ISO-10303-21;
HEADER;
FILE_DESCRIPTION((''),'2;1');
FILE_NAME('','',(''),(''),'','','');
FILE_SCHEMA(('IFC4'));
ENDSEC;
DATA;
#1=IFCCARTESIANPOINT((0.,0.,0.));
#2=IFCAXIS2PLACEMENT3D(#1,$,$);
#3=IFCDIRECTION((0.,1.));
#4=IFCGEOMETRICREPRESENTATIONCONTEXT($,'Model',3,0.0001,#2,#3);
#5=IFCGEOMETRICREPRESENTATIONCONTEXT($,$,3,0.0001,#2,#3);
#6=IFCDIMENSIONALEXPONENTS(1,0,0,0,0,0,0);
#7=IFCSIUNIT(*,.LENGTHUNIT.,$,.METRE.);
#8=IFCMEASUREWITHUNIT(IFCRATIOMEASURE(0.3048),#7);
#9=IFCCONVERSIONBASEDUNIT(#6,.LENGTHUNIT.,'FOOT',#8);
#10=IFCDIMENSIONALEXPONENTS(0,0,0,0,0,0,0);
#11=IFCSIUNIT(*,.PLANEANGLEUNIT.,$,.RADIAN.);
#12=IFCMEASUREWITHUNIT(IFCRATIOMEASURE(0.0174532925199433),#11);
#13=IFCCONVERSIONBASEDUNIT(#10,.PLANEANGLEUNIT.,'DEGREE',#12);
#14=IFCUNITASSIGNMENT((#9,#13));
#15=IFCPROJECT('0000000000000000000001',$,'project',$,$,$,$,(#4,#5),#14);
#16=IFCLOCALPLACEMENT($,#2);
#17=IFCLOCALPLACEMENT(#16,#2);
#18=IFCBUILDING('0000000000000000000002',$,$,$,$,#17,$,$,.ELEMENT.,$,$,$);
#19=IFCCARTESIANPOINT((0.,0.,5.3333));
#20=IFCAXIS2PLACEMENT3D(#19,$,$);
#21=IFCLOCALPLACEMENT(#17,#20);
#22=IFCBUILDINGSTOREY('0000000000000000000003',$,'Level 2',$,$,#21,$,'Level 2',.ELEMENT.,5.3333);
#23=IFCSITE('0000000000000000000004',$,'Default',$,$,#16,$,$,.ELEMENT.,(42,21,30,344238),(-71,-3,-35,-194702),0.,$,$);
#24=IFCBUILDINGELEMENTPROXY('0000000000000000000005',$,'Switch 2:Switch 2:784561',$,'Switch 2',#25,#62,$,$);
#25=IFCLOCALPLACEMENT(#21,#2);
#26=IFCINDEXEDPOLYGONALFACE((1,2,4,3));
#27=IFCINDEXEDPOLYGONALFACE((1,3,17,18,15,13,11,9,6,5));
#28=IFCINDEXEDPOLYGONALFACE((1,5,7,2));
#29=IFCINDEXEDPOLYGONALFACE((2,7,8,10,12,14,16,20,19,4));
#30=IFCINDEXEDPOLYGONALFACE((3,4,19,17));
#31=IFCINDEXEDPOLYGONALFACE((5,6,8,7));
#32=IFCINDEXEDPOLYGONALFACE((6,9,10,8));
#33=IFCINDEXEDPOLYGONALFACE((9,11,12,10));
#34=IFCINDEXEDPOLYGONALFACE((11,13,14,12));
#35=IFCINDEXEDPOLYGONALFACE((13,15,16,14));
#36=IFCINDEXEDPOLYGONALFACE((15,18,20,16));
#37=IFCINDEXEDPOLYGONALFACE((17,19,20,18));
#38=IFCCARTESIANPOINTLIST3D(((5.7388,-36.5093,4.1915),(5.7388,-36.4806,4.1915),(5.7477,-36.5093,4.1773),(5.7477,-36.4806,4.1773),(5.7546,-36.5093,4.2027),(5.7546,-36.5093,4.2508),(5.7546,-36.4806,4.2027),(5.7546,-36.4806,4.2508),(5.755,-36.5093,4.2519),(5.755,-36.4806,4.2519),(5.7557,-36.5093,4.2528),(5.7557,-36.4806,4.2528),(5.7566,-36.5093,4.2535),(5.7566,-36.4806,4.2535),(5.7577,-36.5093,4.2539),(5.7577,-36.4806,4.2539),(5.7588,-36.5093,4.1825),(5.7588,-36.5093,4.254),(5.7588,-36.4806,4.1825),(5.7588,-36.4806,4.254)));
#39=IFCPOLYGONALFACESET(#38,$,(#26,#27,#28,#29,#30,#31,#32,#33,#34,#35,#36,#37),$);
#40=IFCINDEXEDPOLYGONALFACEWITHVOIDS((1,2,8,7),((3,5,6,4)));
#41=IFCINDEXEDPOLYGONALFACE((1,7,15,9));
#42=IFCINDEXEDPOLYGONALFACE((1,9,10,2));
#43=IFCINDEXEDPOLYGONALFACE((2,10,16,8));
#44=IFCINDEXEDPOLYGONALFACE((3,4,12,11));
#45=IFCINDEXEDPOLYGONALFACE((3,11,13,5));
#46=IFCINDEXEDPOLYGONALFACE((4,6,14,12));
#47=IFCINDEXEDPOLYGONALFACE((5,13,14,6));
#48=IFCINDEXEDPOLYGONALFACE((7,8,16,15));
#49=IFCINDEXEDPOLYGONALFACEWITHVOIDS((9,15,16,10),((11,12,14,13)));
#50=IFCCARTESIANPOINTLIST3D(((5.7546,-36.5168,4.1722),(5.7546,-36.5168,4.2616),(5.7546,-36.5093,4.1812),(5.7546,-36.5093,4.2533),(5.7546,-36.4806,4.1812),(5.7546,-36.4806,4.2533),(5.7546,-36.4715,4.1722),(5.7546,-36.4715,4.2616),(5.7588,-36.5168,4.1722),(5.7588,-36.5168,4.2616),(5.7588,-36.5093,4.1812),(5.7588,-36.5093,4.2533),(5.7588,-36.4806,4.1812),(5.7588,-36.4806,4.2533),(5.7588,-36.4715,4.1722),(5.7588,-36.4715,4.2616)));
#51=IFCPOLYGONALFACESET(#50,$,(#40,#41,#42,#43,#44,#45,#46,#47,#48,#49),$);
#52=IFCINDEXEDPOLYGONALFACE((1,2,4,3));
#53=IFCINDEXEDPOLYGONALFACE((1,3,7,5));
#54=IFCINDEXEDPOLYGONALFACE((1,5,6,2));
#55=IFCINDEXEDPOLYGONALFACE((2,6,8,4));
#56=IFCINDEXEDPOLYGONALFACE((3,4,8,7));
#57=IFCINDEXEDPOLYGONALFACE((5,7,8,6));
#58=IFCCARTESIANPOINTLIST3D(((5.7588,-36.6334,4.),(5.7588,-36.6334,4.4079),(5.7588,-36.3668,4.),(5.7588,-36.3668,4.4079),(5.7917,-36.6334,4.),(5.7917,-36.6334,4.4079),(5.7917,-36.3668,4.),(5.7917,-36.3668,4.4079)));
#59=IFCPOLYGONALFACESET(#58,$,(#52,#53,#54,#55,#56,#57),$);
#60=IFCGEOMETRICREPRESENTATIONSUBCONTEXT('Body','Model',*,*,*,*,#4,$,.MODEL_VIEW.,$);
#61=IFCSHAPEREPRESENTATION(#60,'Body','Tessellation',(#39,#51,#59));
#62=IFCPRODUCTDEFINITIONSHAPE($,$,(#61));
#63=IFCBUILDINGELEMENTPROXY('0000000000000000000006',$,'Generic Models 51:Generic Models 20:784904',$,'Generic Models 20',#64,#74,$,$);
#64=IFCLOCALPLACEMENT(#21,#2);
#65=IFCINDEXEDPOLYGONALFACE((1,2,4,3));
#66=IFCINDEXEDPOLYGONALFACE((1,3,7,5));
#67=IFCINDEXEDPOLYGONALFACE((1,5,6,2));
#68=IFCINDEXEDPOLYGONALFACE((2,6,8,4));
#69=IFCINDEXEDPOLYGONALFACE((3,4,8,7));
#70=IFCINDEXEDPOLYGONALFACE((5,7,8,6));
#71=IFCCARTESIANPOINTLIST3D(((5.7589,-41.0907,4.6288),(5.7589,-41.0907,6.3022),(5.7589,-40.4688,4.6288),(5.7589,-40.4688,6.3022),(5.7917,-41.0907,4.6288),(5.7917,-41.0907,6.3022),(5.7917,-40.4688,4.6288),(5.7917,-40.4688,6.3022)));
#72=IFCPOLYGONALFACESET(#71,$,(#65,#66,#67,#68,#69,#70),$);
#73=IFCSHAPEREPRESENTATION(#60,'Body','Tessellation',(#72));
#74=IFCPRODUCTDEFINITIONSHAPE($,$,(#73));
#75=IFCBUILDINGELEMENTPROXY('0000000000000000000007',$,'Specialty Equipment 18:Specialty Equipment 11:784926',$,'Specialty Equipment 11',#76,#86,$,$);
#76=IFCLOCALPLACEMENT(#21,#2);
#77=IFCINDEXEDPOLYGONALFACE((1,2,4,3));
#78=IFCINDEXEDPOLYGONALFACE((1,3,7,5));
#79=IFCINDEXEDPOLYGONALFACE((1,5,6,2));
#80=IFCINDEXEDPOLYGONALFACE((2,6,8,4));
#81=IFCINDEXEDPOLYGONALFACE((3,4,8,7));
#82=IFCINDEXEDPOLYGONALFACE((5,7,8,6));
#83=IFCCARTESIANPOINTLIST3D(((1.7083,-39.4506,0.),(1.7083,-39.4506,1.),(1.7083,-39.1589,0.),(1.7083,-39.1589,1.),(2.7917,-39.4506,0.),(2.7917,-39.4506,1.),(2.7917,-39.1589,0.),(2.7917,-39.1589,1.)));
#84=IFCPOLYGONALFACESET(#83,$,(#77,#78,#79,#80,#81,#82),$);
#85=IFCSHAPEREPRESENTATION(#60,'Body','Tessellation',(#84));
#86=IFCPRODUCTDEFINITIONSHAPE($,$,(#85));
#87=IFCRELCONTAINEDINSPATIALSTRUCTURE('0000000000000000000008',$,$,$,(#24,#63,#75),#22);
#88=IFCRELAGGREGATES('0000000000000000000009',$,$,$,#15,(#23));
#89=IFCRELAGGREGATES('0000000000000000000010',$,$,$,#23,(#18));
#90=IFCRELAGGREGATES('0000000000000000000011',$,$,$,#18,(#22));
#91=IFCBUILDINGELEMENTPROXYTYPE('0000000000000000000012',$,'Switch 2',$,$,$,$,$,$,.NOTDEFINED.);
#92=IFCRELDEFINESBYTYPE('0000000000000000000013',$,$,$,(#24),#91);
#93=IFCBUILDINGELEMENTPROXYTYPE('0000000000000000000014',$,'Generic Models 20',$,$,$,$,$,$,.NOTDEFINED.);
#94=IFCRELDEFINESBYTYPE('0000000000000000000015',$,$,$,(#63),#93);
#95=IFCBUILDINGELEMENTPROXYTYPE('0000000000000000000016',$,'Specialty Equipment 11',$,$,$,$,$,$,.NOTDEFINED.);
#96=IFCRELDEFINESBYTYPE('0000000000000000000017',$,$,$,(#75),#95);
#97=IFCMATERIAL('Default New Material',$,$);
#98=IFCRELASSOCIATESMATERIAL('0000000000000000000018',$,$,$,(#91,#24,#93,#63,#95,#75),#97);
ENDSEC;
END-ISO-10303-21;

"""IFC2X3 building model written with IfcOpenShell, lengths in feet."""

from ifc_helpers import new_model, entity, si_unit, converted_unit, direction, frame, frame_2d, origin, origin_2d_with_axis, place, context, subcontext, project, spatial, polyline, circle_curve, parameter, trimmed, segment, composite_curve, rectangle, outline, extrude, source, transform, mapped, material, type_object, type_shapes, element, save


model = new_model("IFC2X3")

# Units and contexts
model_context = context("Model", 3, precision=0.0001, world=origin(), true_north=direction((0.0, 1.0)))
context_of_model = context(None, 3, precision=0.0001, world=origin(), true_north=direction((0.0, 1.0)))
body_context = subcontext(model_context, "Body", "Model", "MODEL_VIEW")
ifc_project = project(units=[converted_unit("LENGTHUNIT", "FOOT", entity("IfcRatioMeasure", 0.3048), si_unit("LENGTHUNIT", "METRE"), dimensions=[1, 0, 0, 0, 0, 0, 0]), converted_unit("PLANEANGLEUNIT", "DEGREE", entity("IfcRatioMeasure", 0.0174532925199433), si_unit("PLANEANGLEUNIT", "RADIAN"), dimensions=[0, 0, 0, 0, 0, 0, 0])], contexts=[model_context, context_of_model])

# Site, building, storey
site_placement = place(None, origin())
site = spatial("IfcSite", under=ifc_project, at=site_placement, Name="Default", CompositionType="ELEMENT", RefLatitude=(42, 21, 30, 344238), RefLongitude=(-71, -3, -35, -194702), RefElevation=0.0)
building_placement = place(site_placement, origin())
building = spatial("IfcBuilding", under=site, at=building_placement, CompositionType="ELEMENT")
storey_placement = place(building_placement, frame((0.0, 0.0, 5.3333)))
storey = spatial("IfcBuildingStorey", under=building, at=storey_placement, Name="Level 2", LongName="Level 2", CompositionType="ELEMENT", Elevation=5.3333)

# Shared definitions
ifc_material = material(Name="Default New Material")

# Building element proxies
building_element_proxy_type_1 = type_object("IfcBuildingElementProxyType", Name="Switch 2", PredefinedType="NOTDEFINED", material=ifc_material)
shared_shape_1 = source(origin(), body_context, "Body", "SweptSolid", [
    extrude(outline(composite_curve([segment(polyline([(-0.0252, -0.0211), (-0.0084, -0.0211)]), True, "CONTINUOUS"), segment(polyline([(-0.0084, -0.0211), (-0.0073, -0.0017)]), True, "CONTINUOUS"), segment(polyline([(-0.0073, -0.0017), (0.0336, 0.0237)]), True, "CONTINUOUS"), segment(trimmed(circle_curve(frame_2d((0.0308, 0.0266), x_axis=(0.848706, 0.528865)), 0.004), [parameter(281.689503)], [parameter(4.471238)], True, "PARAMETER"), True, "CONTINUOUS"), segment(polyline([(0.034, 0.029), (-0.0267, -0.0088)]), True, "CONTINUOUS"), segment(polyline([(-0.0267, -0.0088), (-0.0252, -0.0211)]), True, "CONTINUOUS")], self_intersect=False)), frame((-0.0093, 0.0394, 0.2098), z_axis=(1.0, 0.0, 0.0), x_axis=(0.0, 0.528865, 0.848706)), (0.0, 0.0, 1.0), 0.0287),
    extrude(outline(polyline([(-0.0447, -0.0227), (0.0447, -0.0227), (0.0447, 0.0227), (-0.0447, 0.0227), (-0.0447, -0.0227)]), holes=[polyline([(-0.0364, -0.0136), (-0.0364, 0.0151), (0.0357, 0.0151), (0.0357, -0.0136), (-0.0364, -0.0136)])]), frame((0.0058, 0.0329, 0.2169), z_axis=(0.0, 1.0, 0.0), x_axis=(0.0, 0.0, -1.0)), (0.0, 0.0, 1.0), 0.0042),
    extrude(rectangle(XDim=0.0329, YDim=0.2666, at=origin_2d_with_axis()), frame((-0.0001, 0.0164, 0.0), z_axis=(0.0, 0.0, 1.0), x_axis=(0.0, -1.0, 0.0)), (0.0, 0.0, 1.0), 0.4079),
])
type_shapes(building_element_proxy_type_1, [shared_shape_1])
proxy_1_placement = place(storey_placement, frame((5.7917, -36.5, 4.0), z_axis=(0.0, 0.0, 1.0), x_axis=(0.0, 1.0, 0.0)))
element("IfcBuildingElementProxy", 1, at=proxy_1_placement, inside=storey, type_object=building_element_proxy_type_1, material=ifc_material, Name="Switch 2:Switch 2:784561", ObjectType="Switch 2", context=body_context, shape_type="MappedRepresentation", body=[
    mapped(shared_shape_1, transform((0.0, 0.0, 0.0), scale=1.0)),
])
building_element_proxy_type_2 = type_object("IfcBuildingElementProxyType", Name="Generic Models 20", PredefinedType="NOTDEFINED", material=ifc_material)
shared_shape_2 = source(origin(), body_context, "Body", "SweptSolid", [
    extrude(rectangle(XDim=0.0328, YDim=0.6219, at=frame_2d((0.0, 0.0), x_axis=(1.0, 0.0))), frame((0.0164, 0.311, 0.0)), (0.0, 0.0, 1.0), 1.6734),
])
type_shapes(building_element_proxy_type_2, [shared_shape_2])
proxy_2_placement = place(storey_placement, frame((5.7589, -41.0907, 4.6288)))
element("IfcBuildingElementProxy", 2, at=proxy_2_placement, inside=storey, type_object=building_element_proxy_type_2, material=ifc_material, Name="Generic Models 51:Generic Models 20:784904", ObjectType="Generic Models 20", context=body_context, shape_type="MappedRepresentation", body=[
    mapped(shared_shape_2, transform((0.0, 0.0, 0.0), scale=1.0)),
])
building_element_proxy_type_3 = type_object("IfcBuildingElementProxyType", Name="Specialty Equipment 11", PredefinedType="NOTDEFINED", material=ifc_material)
shared_shape_3 = source(origin(), body_context, "Body", "SweptSolid", [
    extrude(rectangle(XDim=1.0833, YDim=0.2917, at=frame_2d((0.0, 0.0), x_axis=(1.0, 0.0))), frame((0.5417, 0.1458, 0.0), z_axis=(0.0, 0.0, 1.0), x_axis=(-1.0, 0.0, 0.0)), (0.0, 0.0, 1.0), 1.0),
])
type_shapes(building_element_proxy_type_3, [shared_shape_3])
proxy_3_placement = place(storey_placement, frame((1.7083, -39.4506, 0.0)))
element("IfcBuildingElementProxy", 3, at=proxy_3_placement, inside=storey, type_object=building_element_proxy_type_3, material=ifc_material, Name="Specialty Equipment 18:Specialty Equipment 11:784926", ObjectType="Specialty Equipment 11", context=body_context, shape_type="MappedRepresentation", body=[
    mapped(shared_shape_3, transform((0.0, 0.0, 0.0), scale=1.0)),
])

save(model, "model.ifc")
